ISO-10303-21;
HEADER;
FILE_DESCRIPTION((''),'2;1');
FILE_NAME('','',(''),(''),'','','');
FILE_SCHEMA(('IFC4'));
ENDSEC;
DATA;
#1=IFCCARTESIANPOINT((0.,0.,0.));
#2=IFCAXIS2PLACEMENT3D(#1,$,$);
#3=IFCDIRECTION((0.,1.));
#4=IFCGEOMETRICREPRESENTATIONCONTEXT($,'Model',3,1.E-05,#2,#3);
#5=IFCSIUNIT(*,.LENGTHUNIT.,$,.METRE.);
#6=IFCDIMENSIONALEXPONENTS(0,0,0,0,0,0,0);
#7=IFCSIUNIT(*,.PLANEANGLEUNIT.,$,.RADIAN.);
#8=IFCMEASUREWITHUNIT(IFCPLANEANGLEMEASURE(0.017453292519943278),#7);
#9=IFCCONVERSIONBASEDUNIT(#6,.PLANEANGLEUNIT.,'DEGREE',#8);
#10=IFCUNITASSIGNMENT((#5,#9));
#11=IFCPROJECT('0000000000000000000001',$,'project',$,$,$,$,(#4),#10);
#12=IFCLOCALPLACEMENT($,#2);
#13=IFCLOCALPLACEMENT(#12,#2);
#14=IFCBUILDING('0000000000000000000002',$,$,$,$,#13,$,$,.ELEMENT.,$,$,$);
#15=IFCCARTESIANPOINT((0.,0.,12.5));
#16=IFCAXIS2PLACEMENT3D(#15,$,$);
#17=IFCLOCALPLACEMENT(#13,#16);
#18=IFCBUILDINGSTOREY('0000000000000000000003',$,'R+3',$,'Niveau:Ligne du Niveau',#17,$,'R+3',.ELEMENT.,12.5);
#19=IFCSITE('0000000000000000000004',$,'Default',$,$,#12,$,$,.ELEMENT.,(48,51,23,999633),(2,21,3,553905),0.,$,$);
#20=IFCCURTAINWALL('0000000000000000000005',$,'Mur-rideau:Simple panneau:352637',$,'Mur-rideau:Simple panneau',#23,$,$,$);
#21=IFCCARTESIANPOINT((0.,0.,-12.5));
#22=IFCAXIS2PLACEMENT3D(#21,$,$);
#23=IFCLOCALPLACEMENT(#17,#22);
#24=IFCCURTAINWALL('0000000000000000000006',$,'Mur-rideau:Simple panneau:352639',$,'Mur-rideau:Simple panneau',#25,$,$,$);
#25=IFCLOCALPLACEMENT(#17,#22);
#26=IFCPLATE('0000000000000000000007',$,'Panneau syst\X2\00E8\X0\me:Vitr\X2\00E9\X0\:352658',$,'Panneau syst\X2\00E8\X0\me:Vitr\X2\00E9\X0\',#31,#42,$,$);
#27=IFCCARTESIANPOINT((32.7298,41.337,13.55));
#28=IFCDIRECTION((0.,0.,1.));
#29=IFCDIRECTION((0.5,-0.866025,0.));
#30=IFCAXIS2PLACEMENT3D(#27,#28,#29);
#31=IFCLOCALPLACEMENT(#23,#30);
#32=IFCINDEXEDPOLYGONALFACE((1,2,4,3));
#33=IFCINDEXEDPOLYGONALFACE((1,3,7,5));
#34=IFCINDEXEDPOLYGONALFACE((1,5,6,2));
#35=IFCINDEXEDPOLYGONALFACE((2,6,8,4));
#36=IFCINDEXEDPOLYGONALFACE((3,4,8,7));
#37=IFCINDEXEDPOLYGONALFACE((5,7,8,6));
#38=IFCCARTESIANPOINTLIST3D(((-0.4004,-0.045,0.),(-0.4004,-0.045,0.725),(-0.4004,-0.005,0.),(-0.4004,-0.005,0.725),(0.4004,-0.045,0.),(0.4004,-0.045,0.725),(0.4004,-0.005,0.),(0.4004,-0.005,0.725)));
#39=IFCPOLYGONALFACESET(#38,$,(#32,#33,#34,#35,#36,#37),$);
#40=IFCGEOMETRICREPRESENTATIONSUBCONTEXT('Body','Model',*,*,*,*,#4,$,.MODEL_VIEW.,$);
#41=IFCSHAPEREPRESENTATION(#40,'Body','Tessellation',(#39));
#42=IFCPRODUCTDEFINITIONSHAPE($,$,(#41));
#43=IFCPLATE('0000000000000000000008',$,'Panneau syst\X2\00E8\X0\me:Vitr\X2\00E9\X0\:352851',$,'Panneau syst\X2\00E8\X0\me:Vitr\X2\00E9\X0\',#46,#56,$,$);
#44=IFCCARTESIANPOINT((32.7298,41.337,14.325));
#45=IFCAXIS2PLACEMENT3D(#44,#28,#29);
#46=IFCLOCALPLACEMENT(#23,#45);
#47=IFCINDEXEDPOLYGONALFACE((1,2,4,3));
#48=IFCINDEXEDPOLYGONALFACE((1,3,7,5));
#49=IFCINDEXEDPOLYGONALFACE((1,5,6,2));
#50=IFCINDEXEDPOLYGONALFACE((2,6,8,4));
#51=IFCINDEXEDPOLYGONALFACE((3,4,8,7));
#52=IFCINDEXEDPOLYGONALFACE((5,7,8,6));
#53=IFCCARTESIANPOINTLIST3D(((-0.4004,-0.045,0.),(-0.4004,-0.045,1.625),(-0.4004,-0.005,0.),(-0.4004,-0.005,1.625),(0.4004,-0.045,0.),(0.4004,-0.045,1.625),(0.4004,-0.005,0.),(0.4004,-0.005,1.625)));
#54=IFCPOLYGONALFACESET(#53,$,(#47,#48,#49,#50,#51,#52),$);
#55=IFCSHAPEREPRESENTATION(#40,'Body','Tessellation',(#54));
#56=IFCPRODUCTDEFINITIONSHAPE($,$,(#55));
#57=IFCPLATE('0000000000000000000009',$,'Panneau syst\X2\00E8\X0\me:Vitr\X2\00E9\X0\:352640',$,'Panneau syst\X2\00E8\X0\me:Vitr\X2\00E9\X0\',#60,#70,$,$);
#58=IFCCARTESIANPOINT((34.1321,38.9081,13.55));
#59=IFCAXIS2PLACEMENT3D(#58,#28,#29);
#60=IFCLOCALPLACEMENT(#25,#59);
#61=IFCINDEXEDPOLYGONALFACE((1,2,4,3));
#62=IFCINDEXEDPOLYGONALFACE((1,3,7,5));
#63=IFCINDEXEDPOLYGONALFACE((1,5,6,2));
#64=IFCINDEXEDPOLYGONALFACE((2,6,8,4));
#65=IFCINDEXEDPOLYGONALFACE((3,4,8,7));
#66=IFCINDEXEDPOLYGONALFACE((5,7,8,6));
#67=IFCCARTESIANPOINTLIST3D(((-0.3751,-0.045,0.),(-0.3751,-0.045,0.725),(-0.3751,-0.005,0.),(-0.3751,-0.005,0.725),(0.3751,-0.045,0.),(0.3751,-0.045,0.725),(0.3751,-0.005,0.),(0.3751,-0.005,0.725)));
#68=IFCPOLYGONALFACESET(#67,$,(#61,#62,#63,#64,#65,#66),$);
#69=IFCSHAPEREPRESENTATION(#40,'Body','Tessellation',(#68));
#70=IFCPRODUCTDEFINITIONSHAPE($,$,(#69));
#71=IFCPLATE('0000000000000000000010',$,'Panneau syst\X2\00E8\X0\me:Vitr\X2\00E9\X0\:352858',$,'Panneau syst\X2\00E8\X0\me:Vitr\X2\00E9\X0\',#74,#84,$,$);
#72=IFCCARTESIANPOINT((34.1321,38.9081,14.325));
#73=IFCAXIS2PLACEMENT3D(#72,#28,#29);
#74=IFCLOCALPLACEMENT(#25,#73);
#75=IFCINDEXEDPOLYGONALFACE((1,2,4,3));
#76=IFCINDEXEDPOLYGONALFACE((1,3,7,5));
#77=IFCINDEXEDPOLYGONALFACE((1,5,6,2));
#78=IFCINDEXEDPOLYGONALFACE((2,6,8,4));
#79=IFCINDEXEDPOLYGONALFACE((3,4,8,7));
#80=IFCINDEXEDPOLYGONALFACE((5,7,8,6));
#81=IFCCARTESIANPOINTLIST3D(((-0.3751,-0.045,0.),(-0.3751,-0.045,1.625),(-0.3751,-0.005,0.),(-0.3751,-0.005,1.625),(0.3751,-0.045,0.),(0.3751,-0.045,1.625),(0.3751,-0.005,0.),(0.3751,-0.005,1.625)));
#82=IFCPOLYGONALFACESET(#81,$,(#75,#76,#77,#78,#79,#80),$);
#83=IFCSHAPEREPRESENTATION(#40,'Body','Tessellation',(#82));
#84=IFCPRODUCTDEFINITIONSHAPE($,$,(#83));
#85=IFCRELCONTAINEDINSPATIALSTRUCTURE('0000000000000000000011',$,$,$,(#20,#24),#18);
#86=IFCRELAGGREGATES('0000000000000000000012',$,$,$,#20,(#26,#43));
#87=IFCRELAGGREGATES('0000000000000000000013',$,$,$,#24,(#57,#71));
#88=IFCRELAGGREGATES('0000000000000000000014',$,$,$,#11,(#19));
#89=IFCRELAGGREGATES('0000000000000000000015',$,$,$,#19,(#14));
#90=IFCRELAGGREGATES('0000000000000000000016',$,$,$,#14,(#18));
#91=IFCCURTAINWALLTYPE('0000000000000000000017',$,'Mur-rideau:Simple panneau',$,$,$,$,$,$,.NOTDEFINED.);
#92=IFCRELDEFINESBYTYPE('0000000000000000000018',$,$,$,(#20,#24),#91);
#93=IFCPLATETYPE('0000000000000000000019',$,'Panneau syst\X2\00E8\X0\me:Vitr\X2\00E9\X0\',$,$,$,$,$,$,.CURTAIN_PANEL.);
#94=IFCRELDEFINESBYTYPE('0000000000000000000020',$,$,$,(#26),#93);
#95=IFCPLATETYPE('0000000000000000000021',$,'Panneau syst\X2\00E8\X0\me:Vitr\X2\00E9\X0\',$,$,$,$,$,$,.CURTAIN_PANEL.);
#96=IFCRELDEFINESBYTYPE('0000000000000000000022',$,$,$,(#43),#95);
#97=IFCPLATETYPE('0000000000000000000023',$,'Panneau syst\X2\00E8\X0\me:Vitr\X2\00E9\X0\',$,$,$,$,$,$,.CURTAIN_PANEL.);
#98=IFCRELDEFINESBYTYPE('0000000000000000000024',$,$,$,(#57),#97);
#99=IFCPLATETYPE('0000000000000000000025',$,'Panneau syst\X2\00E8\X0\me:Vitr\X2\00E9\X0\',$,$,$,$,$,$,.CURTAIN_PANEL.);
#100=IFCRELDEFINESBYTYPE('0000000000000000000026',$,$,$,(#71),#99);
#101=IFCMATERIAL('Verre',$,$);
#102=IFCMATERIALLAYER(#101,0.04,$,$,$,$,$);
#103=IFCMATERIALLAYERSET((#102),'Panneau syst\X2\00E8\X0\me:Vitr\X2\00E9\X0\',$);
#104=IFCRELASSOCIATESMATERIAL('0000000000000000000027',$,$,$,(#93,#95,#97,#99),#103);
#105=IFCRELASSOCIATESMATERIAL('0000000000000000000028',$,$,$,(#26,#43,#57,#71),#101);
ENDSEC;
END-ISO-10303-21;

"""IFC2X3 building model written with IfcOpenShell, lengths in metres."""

from ifc_helpers import new_model, entity, si_unit, converted_unit, direction, frame, frame_2d, origin, place, context, subcontext, project, spatial, rectangle, extrude, source, transform, mapped, material, layer, layer_set, type_object, type_shapes, element, aggregate, save


model = new_model("IFC2X3")

# Units and contexts
model_context = context("Model", 3, precision=1e-05, world=origin(), true_north=direction((0.0, 1.0)))
body_context = subcontext(model_context, "Body", "Model", "MODEL_VIEW")
ifc_project = project(units=[si_unit("LENGTHUNIT", "METRE"), converted_unit("PLANEANGLEUNIT", "DEGREE", entity("IfcPlaneAngleMeasure", 0.017453292519943278), si_unit("PLANEANGLEUNIT", "RADIAN"), dimensions=[0, 0, 0, 0, 0, 0, 0])], contexts=[model_context])

# Site, building, storey
site_placement = place(None, origin())
site = spatial("IfcSite", under=ifc_project, at=site_placement, Name="Default", CompositionType="ELEMENT", RefLatitude=(48, 51, 23, 999633), RefLongitude=(2, 21, 3, 553905), RefElevation=0.0)
building_placement = place(site_placement, origin())
building = spatial("IfcBuilding", under=site, at=building_placement, CompositionType="ELEMENT")
storey_placement = place(building_placement, frame((0.0, 0.0, 12.5)))
storey = spatial("IfcBuildingStorey", under=building, at=storey_placement, Name="R+3", ObjectType="Niveau:Ligne du Niveau", LongName="R+3", CompositionType="ELEMENT", Elevation=12.5)

# Curtain walls
curtain_wall_type = type_object("IfcCurtainWallType", Name="Mur-rideau:Simple panneau", PredefinedType="NOTDEFINED")
curtain_wall_1_placement = place(storey_placement, frame((0.0, 0.0, -12.5)))
curtain_wall_1 = element("IfcCurtainWall", 1, at=curtain_wall_1_placement, inside=storey, type_object=curtain_wall_type, Name="Mur-rideau:Simple panneau:352637", ObjectType="Mur-rideau:Simple panneau")
curtain_wall_2_placement = place(storey_placement, frame((0.0, 0.0, -12.5)))
curtain_wall_2 = element("IfcCurtainWall", 2, at=curtain_wall_2_placement, inside=storey, type_object=curtain_wall_type, Name="Mur-rideau:Simple panneau:352639", ObjectType="Mur-rideau:Simple panneau")

# Plates
ifc_material_1 = material(Name="Verre")
ifc_layer_1 = layer(ifc_material_1, 0.04)
ifc_layer_set_1 = layer_set([ifc_layer_1], Name="Panneau système:Vitré")
plate_type_1 = type_object("IfcPlateType", Name="Panneau système:Vitré", PredefinedType="CURTAIN_PANEL", material=ifc_layer_set_1)
shared_shape_1 = source(origin(), body_context, "Body", "SweptSolid", [
    extrude(rectangle(XDim=0.04, YDim=0.8008, at=frame_2d((0.0, 0.0), x_axis=(1.0, 0.0))), frame((0.0, -0.025, 0.0), z_axis=(0.0, 0.0, 1.0), x_axis=(0.0, 1.0, 0.0)), (0.0, 0.0, 1.0), 0.725),
])
type_shapes(plate_type_1, [shared_shape_1])
plate_1_placement = place(curtain_wall_1_placement, frame((32.7298, 41.337, 13.55), z_axis=(0.0, 0.0, 1.0), x_axis=(0.5, -0.866025, 0.0)))
plate_1 = element("IfcPlate", 3, at=plate_1_placement, type_object=plate_type_1, material=ifc_material_1, Name="Panneau système:Vitré:352658", ObjectType="Panneau système:Vitré", context=body_context, shape_type="MappedRepresentation", body=[
    mapped(shared_shape_1, transform((0.0, 0.0, 0.0), scale=1.0)),
])
plate_type_2 = type_object("IfcPlateType", Name="Panneau système:Vitré", PredefinedType="CURTAIN_PANEL", material=ifc_layer_set_1)
shared_shape_2 = source(origin(), body_context, "Body", "SweptSolid", [
    extrude(rectangle(XDim=0.04, YDim=0.8008, at=frame_2d((0.0, 0.0), x_axis=(1.0, 0.0))), frame((0.0, -0.025, 0.0), z_axis=(0.0, 0.0, 1.0), x_axis=(0.0, 1.0, 0.0)), (0.0, 0.0, 1.0), 1.625),
])
type_shapes(plate_type_2, [shared_shape_2])
plate_2_placement = place(curtain_wall_1_placement, frame((32.7298, 41.337, 14.325), z_axis=(0.0, 0.0, 1.0), x_axis=(0.5, -0.866025, 0.0)))
plate_2 = element("IfcPlate", 4, at=plate_2_placement, type_object=plate_type_2, material=ifc_material_1, Name="Panneau système:Vitré:352851", ObjectType="Panneau système:Vitré", context=body_context, shape_type="MappedRepresentation", body=[
    mapped(shared_shape_2, transform((0.0, 0.0, 0.0), scale=1.0)),
])
aggregate(curtain_wall_1, [plate_1, plate_2])
plate_type_3 = type_object("IfcPlateType", Name="Panneau système:Vitré", PredefinedType="CURTAIN_PANEL", material=ifc_layer_set_1)
shared_shape_3 = source(origin(), body_context, "Body", "SweptSolid", [
    extrude(rectangle(XDim=0.04, YDim=0.7503, at=frame_2d((0.0, 0.0), x_axis=(1.0, 0.0))), frame((0.0, -0.025, 0.0), z_axis=(0.0, 0.0, 1.0), x_axis=(0.0, 1.0, 0.0)), (0.0, 0.0, 1.0), 0.725),
])
type_shapes(plate_type_3, [shared_shape_3])
plate_3_placement = place(curtain_wall_2_placement, frame((34.1321, 38.9081, 13.55), z_axis=(0.0, 0.0, 1.0), x_axis=(0.5, -0.866025, 0.0)))
plate_3 = element("IfcPlate", 5, at=plate_3_placement, type_object=plate_type_3, material=ifc_material_1, Name="Panneau système:Vitré:352640", ObjectType="Panneau système:Vitré", context=body_context, shape_type="MappedRepresentation", body=[
    mapped(shared_shape_3, transform((0.0, 0.0, 0.0), scale=1.0)),
])
plate_type_4 = type_object("IfcPlateType", Name="Panneau système:Vitré", PredefinedType="CURTAIN_PANEL", material=ifc_layer_set_1)
shared_shape_4 = source(origin(), body_context, "Body", "SweptSolid", [
    extrude(rectangle(XDim=0.04, YDim=0.7503, at=frame_2d((0.0, 0.0), x_axis=(1.0, 0.0))), frame((0.0, -0.025, 0.0), z_axis=(0.0, 0.0, 1.0), x_axis=(0.0, 1.0, 0.0)), (0.0, 0.0, 1.0), 1.625),
])
type_shapes(plate_type_4, [shared_shape_4])
plate_4_placement = place(curtain_wall_2_placement, frame((34.1321, 38.9081, 14.325), z_axis=(0.0, 0.0, 1.0), x_axis=(0.5, -0.866025, 0.0)))
plate_4 = element("IfcPlate", 6, at=plate_4_placement, type_object=plate_type_4, material=ifc_material_1, Name="Panneau système:Vitré:352858", ObjectType="Panneau système:Vitré", context=body_context, shape_type="MappedRepresentation", body=[
    mapped(shared_shape_4, transform((0.0, 0.0, 0.0), scale=1.0)),
])
aggregate(curtain_wall_2, [plate_3, plate_4])

save(model, "model.ifc")
